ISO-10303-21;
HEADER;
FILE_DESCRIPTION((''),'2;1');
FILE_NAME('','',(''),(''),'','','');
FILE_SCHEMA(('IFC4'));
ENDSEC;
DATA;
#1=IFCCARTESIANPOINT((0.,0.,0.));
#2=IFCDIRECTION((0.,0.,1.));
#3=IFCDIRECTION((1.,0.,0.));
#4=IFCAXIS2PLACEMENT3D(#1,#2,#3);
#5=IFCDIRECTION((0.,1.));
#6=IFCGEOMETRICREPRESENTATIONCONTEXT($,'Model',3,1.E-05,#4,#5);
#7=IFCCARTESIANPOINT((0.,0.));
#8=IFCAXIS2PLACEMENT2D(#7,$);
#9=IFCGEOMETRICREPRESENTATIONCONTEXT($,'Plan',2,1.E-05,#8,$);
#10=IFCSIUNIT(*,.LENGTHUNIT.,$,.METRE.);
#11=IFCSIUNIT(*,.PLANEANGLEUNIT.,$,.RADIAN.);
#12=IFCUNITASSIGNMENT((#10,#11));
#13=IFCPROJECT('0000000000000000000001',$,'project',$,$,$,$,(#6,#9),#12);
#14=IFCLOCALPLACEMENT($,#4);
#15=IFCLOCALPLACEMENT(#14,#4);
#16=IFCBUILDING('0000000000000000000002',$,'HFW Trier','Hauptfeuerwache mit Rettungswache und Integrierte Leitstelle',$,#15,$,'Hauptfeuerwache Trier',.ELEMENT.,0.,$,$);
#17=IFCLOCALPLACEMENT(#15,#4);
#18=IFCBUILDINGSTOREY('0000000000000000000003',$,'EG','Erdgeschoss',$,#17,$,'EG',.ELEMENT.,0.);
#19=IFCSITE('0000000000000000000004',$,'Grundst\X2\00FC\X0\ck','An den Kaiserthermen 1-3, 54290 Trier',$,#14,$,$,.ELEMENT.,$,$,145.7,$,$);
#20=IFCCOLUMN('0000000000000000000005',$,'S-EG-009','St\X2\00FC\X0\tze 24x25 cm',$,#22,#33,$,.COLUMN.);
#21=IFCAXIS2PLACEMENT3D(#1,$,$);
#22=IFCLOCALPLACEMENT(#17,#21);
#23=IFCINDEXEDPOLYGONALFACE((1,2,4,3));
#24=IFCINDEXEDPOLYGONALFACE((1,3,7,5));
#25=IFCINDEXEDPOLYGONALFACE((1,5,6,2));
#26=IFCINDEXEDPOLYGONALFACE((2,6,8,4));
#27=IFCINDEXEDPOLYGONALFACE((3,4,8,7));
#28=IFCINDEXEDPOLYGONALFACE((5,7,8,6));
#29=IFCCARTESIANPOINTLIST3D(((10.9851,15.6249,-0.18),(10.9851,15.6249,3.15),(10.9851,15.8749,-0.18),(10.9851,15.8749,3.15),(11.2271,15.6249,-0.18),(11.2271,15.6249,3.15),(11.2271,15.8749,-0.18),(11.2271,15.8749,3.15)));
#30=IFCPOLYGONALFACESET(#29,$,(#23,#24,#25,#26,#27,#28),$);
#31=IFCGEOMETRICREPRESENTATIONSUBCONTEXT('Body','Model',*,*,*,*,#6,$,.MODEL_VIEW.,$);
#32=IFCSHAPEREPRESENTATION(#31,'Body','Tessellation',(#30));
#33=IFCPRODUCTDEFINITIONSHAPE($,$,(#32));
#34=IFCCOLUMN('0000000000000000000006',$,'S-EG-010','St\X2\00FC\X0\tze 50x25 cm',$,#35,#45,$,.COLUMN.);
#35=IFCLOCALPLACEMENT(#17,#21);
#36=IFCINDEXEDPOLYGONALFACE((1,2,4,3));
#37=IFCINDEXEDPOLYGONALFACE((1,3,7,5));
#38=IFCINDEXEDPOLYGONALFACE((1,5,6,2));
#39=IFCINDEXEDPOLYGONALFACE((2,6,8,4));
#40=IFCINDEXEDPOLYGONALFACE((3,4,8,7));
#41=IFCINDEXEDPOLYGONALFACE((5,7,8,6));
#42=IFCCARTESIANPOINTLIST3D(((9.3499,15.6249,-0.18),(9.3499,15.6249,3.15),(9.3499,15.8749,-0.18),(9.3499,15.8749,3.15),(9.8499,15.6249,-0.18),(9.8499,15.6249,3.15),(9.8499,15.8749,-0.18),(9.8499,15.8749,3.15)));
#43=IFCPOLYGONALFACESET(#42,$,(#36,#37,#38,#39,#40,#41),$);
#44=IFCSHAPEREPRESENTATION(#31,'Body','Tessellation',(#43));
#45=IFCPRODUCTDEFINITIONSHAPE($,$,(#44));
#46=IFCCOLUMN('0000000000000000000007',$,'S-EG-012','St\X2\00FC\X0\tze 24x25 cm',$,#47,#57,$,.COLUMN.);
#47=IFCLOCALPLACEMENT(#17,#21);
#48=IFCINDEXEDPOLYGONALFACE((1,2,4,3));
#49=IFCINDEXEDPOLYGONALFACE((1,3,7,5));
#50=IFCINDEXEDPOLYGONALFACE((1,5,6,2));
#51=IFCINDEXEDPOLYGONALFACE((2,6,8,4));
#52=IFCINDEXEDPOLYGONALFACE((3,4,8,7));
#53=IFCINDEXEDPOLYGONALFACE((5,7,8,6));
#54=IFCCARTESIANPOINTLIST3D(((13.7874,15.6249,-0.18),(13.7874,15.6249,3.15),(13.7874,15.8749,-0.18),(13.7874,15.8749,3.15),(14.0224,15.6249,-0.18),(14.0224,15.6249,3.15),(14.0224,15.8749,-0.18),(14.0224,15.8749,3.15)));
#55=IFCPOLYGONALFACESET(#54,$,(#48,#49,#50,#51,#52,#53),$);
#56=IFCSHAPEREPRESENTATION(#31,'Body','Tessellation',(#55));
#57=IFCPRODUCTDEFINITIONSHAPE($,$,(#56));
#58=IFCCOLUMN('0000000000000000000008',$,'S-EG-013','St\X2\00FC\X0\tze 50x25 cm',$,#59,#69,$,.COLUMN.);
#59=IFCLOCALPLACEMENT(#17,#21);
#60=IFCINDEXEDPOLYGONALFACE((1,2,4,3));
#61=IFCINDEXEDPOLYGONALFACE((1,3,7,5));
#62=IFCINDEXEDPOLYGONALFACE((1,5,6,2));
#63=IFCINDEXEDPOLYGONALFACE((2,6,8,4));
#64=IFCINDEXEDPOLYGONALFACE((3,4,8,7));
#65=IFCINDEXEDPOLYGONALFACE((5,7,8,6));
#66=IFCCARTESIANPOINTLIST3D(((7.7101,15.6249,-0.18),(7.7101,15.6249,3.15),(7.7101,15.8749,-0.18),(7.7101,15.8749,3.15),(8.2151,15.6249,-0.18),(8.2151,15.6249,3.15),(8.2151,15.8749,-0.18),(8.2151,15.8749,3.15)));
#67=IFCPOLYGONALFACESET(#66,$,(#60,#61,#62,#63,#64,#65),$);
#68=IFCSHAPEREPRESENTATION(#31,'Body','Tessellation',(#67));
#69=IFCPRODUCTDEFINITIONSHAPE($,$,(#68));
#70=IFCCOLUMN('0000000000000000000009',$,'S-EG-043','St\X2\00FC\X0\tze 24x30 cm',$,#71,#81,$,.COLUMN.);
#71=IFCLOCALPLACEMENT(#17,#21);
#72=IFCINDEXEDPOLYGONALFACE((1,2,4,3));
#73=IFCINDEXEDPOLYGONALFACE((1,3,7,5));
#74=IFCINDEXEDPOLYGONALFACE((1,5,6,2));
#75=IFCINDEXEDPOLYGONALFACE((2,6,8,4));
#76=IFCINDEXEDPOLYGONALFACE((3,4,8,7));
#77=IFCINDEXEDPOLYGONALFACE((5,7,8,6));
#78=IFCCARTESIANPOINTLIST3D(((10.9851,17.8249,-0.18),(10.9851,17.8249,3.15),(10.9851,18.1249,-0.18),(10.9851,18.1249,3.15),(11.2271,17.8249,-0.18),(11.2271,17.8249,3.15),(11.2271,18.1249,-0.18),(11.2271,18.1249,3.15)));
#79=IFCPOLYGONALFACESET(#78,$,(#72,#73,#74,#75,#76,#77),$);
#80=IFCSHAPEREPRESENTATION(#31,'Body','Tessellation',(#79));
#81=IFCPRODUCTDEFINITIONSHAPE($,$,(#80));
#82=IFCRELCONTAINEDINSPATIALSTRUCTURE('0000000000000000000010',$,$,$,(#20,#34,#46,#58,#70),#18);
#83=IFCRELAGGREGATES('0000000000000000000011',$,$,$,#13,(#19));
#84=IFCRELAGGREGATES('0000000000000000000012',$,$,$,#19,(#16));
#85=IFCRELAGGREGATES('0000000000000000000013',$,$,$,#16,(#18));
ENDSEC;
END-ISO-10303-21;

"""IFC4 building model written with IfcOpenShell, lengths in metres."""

from ifc_helpers import new_model, si_unit, direction, frame, frame_2d, origin_with_axes, origin_2d, place, context, subcontext, project, spatial, rectangle, extrude, element, save


model = new_model("IFC4")

# Units and contexts
model_context = context("Model", 3, precision=1e-05, world=origin_with_axes(), true_north=direction((0.0, 1.0)))
plan_context = context("Plan", 2, precision=1e-05, world=origin_2d())
body_context = subcontext(model_context, "Body", "Model", "MODEL_VIEW")
ifc_project = project(units=[si_unit("LENGTHUNIT", "METRE"), si_unit("PLANEANGLEUNIT", "RADIAN")], contexts=[model_context, plan_context])

# Site, building, storey
site_placement = place(None, origin_with_axes())
site = spatial("IfcSite", under=ifc_project, at=site_placement, Name="Grundstück", Description="An den Kaiserthermen 1-3, 54290 Trier", CompositionType="ELEMENT", RefElevation=145.7)
building_placement = place(site_placement, origin_with_axes())
building = spatial("IfcBuilding", under=site, at=building_placement, Name="HFW Trier", Description="Hauptfeuerwache mit Rettungswache und Integrierte Leitstelle", LongName="Hauptfeuerwache Trier", CompositionType="ELEMENT", ElevationOfRefHeight=0.0)
storey_placement = place(building_placement, origin_with_axes())
storey = spatial("IfcBuildingStorey", under=building, at=storey_placement, Name="EG", Description="Erdgeschoss", LongName="EG", CompositionType="ELEMENT", Elevation=0.0)

# Columns
column_1_placement = place(storey_placement, frame((10.9851, 15.7499, -0.18), z_axis=(0.0, 0.0, 1.0), x_axis=(1.0, 0.0, 0.0)))
element("IfcColumn", 1, at=column_1_placement, inside=storey, Name="S-EG-009", Description="Stütze 24x25 cm", PredefinedType="COLUMN", context=body_context, shape_type="SweptSolid", body=[
    extrude(rectangle(XDim=0.242, YDim=0.25, at=frame_2d((0.121, 0.0))), origin_with_axes(), (0.0, 0.0, 1.0), 3.33),
])
column_2_placement = place(storey_placement, frame((9.3499, 15.7499, -0.18), z_axis=(0.0, 0.0, 1.0), x_axis=(1.0, 0.0, 0.0)))
element("IfcColumn", 2, at=column_2_placement, inside=storey, Name="S-EG-010", Description="Stütze 50x25 cm", PredefinedType="COLUMN", context=body_context, shape_type="SweptSolid", body=[
    extrude(rectangle(XDim=0.5, YDim=0.25, at=frame_2d((0.25, 0.0))), origin_with_axes(), (0.0, 0.0, 1.0), 3.33),
])
column_3_placement = place(storey_placement, frame((13.7874, 15.7499, -0.18), z_axis=(0.0, 0.0, 1.0), x_axis=(1.0, 0.0, 0.0)))
element("IfcColumn", 3, at=column_3_placement, inside=storey, Name="S-EG-012", Description="Stütze 24x25 cm", PredefinedType="COLUMN", context=body_context, shape_type="SweptSolid", body=[
    extrude(rectangle(XDim=0.235, YDim=0.25, at=frame_2d((0.1175, 0.0))), origin_with_axes(), (0.0, 0.0, 1.0), 3.33),
])
column_4_placement = place(storey_placement, frame((7.7101, 15.7499, -0.18), z_axis=(0.0, 0.0, 1.0), x_axis=(1.0, 0.0, 0.0)))
element("IfcColumn", 4, at=column_4_placement, inside=storey, Name="S-EG-013", Description="Stütze 50x25 cm", PredefinedType="COLUMN", context=body_context, shape_type="SweptSolid", body=[
    extrude(rectangle(XDim=0.505, YDim=0.25, at=frame_2d((0.2525, 0.0))), origin_with_axes(), (0.0, 0.0, 1.0), 3.33),
])
column_5_placement = place(storey_placement, frame((10.9851, 17.9749, -0.18), z_axis=(0.0, 0.0, 1.0), x_axis=(1.0, 0.0, 0.0)))
element("IfcColumn", 5, at=column_5_placement, inside=storey, Name="S-EG-043", Description="Stütze 24x30 cm", PredefinedType="COLUMN", context=body_context, shape_type="SweptSolid", body=[
    extrude(rectangle(XDim=0.242, YDim=0.3, at=frame_2d((0.121, 0.0))), origin_with_axes(), (0.0, 0.0, 1.0), 3.33),
])

save(model, "model.ifc")
